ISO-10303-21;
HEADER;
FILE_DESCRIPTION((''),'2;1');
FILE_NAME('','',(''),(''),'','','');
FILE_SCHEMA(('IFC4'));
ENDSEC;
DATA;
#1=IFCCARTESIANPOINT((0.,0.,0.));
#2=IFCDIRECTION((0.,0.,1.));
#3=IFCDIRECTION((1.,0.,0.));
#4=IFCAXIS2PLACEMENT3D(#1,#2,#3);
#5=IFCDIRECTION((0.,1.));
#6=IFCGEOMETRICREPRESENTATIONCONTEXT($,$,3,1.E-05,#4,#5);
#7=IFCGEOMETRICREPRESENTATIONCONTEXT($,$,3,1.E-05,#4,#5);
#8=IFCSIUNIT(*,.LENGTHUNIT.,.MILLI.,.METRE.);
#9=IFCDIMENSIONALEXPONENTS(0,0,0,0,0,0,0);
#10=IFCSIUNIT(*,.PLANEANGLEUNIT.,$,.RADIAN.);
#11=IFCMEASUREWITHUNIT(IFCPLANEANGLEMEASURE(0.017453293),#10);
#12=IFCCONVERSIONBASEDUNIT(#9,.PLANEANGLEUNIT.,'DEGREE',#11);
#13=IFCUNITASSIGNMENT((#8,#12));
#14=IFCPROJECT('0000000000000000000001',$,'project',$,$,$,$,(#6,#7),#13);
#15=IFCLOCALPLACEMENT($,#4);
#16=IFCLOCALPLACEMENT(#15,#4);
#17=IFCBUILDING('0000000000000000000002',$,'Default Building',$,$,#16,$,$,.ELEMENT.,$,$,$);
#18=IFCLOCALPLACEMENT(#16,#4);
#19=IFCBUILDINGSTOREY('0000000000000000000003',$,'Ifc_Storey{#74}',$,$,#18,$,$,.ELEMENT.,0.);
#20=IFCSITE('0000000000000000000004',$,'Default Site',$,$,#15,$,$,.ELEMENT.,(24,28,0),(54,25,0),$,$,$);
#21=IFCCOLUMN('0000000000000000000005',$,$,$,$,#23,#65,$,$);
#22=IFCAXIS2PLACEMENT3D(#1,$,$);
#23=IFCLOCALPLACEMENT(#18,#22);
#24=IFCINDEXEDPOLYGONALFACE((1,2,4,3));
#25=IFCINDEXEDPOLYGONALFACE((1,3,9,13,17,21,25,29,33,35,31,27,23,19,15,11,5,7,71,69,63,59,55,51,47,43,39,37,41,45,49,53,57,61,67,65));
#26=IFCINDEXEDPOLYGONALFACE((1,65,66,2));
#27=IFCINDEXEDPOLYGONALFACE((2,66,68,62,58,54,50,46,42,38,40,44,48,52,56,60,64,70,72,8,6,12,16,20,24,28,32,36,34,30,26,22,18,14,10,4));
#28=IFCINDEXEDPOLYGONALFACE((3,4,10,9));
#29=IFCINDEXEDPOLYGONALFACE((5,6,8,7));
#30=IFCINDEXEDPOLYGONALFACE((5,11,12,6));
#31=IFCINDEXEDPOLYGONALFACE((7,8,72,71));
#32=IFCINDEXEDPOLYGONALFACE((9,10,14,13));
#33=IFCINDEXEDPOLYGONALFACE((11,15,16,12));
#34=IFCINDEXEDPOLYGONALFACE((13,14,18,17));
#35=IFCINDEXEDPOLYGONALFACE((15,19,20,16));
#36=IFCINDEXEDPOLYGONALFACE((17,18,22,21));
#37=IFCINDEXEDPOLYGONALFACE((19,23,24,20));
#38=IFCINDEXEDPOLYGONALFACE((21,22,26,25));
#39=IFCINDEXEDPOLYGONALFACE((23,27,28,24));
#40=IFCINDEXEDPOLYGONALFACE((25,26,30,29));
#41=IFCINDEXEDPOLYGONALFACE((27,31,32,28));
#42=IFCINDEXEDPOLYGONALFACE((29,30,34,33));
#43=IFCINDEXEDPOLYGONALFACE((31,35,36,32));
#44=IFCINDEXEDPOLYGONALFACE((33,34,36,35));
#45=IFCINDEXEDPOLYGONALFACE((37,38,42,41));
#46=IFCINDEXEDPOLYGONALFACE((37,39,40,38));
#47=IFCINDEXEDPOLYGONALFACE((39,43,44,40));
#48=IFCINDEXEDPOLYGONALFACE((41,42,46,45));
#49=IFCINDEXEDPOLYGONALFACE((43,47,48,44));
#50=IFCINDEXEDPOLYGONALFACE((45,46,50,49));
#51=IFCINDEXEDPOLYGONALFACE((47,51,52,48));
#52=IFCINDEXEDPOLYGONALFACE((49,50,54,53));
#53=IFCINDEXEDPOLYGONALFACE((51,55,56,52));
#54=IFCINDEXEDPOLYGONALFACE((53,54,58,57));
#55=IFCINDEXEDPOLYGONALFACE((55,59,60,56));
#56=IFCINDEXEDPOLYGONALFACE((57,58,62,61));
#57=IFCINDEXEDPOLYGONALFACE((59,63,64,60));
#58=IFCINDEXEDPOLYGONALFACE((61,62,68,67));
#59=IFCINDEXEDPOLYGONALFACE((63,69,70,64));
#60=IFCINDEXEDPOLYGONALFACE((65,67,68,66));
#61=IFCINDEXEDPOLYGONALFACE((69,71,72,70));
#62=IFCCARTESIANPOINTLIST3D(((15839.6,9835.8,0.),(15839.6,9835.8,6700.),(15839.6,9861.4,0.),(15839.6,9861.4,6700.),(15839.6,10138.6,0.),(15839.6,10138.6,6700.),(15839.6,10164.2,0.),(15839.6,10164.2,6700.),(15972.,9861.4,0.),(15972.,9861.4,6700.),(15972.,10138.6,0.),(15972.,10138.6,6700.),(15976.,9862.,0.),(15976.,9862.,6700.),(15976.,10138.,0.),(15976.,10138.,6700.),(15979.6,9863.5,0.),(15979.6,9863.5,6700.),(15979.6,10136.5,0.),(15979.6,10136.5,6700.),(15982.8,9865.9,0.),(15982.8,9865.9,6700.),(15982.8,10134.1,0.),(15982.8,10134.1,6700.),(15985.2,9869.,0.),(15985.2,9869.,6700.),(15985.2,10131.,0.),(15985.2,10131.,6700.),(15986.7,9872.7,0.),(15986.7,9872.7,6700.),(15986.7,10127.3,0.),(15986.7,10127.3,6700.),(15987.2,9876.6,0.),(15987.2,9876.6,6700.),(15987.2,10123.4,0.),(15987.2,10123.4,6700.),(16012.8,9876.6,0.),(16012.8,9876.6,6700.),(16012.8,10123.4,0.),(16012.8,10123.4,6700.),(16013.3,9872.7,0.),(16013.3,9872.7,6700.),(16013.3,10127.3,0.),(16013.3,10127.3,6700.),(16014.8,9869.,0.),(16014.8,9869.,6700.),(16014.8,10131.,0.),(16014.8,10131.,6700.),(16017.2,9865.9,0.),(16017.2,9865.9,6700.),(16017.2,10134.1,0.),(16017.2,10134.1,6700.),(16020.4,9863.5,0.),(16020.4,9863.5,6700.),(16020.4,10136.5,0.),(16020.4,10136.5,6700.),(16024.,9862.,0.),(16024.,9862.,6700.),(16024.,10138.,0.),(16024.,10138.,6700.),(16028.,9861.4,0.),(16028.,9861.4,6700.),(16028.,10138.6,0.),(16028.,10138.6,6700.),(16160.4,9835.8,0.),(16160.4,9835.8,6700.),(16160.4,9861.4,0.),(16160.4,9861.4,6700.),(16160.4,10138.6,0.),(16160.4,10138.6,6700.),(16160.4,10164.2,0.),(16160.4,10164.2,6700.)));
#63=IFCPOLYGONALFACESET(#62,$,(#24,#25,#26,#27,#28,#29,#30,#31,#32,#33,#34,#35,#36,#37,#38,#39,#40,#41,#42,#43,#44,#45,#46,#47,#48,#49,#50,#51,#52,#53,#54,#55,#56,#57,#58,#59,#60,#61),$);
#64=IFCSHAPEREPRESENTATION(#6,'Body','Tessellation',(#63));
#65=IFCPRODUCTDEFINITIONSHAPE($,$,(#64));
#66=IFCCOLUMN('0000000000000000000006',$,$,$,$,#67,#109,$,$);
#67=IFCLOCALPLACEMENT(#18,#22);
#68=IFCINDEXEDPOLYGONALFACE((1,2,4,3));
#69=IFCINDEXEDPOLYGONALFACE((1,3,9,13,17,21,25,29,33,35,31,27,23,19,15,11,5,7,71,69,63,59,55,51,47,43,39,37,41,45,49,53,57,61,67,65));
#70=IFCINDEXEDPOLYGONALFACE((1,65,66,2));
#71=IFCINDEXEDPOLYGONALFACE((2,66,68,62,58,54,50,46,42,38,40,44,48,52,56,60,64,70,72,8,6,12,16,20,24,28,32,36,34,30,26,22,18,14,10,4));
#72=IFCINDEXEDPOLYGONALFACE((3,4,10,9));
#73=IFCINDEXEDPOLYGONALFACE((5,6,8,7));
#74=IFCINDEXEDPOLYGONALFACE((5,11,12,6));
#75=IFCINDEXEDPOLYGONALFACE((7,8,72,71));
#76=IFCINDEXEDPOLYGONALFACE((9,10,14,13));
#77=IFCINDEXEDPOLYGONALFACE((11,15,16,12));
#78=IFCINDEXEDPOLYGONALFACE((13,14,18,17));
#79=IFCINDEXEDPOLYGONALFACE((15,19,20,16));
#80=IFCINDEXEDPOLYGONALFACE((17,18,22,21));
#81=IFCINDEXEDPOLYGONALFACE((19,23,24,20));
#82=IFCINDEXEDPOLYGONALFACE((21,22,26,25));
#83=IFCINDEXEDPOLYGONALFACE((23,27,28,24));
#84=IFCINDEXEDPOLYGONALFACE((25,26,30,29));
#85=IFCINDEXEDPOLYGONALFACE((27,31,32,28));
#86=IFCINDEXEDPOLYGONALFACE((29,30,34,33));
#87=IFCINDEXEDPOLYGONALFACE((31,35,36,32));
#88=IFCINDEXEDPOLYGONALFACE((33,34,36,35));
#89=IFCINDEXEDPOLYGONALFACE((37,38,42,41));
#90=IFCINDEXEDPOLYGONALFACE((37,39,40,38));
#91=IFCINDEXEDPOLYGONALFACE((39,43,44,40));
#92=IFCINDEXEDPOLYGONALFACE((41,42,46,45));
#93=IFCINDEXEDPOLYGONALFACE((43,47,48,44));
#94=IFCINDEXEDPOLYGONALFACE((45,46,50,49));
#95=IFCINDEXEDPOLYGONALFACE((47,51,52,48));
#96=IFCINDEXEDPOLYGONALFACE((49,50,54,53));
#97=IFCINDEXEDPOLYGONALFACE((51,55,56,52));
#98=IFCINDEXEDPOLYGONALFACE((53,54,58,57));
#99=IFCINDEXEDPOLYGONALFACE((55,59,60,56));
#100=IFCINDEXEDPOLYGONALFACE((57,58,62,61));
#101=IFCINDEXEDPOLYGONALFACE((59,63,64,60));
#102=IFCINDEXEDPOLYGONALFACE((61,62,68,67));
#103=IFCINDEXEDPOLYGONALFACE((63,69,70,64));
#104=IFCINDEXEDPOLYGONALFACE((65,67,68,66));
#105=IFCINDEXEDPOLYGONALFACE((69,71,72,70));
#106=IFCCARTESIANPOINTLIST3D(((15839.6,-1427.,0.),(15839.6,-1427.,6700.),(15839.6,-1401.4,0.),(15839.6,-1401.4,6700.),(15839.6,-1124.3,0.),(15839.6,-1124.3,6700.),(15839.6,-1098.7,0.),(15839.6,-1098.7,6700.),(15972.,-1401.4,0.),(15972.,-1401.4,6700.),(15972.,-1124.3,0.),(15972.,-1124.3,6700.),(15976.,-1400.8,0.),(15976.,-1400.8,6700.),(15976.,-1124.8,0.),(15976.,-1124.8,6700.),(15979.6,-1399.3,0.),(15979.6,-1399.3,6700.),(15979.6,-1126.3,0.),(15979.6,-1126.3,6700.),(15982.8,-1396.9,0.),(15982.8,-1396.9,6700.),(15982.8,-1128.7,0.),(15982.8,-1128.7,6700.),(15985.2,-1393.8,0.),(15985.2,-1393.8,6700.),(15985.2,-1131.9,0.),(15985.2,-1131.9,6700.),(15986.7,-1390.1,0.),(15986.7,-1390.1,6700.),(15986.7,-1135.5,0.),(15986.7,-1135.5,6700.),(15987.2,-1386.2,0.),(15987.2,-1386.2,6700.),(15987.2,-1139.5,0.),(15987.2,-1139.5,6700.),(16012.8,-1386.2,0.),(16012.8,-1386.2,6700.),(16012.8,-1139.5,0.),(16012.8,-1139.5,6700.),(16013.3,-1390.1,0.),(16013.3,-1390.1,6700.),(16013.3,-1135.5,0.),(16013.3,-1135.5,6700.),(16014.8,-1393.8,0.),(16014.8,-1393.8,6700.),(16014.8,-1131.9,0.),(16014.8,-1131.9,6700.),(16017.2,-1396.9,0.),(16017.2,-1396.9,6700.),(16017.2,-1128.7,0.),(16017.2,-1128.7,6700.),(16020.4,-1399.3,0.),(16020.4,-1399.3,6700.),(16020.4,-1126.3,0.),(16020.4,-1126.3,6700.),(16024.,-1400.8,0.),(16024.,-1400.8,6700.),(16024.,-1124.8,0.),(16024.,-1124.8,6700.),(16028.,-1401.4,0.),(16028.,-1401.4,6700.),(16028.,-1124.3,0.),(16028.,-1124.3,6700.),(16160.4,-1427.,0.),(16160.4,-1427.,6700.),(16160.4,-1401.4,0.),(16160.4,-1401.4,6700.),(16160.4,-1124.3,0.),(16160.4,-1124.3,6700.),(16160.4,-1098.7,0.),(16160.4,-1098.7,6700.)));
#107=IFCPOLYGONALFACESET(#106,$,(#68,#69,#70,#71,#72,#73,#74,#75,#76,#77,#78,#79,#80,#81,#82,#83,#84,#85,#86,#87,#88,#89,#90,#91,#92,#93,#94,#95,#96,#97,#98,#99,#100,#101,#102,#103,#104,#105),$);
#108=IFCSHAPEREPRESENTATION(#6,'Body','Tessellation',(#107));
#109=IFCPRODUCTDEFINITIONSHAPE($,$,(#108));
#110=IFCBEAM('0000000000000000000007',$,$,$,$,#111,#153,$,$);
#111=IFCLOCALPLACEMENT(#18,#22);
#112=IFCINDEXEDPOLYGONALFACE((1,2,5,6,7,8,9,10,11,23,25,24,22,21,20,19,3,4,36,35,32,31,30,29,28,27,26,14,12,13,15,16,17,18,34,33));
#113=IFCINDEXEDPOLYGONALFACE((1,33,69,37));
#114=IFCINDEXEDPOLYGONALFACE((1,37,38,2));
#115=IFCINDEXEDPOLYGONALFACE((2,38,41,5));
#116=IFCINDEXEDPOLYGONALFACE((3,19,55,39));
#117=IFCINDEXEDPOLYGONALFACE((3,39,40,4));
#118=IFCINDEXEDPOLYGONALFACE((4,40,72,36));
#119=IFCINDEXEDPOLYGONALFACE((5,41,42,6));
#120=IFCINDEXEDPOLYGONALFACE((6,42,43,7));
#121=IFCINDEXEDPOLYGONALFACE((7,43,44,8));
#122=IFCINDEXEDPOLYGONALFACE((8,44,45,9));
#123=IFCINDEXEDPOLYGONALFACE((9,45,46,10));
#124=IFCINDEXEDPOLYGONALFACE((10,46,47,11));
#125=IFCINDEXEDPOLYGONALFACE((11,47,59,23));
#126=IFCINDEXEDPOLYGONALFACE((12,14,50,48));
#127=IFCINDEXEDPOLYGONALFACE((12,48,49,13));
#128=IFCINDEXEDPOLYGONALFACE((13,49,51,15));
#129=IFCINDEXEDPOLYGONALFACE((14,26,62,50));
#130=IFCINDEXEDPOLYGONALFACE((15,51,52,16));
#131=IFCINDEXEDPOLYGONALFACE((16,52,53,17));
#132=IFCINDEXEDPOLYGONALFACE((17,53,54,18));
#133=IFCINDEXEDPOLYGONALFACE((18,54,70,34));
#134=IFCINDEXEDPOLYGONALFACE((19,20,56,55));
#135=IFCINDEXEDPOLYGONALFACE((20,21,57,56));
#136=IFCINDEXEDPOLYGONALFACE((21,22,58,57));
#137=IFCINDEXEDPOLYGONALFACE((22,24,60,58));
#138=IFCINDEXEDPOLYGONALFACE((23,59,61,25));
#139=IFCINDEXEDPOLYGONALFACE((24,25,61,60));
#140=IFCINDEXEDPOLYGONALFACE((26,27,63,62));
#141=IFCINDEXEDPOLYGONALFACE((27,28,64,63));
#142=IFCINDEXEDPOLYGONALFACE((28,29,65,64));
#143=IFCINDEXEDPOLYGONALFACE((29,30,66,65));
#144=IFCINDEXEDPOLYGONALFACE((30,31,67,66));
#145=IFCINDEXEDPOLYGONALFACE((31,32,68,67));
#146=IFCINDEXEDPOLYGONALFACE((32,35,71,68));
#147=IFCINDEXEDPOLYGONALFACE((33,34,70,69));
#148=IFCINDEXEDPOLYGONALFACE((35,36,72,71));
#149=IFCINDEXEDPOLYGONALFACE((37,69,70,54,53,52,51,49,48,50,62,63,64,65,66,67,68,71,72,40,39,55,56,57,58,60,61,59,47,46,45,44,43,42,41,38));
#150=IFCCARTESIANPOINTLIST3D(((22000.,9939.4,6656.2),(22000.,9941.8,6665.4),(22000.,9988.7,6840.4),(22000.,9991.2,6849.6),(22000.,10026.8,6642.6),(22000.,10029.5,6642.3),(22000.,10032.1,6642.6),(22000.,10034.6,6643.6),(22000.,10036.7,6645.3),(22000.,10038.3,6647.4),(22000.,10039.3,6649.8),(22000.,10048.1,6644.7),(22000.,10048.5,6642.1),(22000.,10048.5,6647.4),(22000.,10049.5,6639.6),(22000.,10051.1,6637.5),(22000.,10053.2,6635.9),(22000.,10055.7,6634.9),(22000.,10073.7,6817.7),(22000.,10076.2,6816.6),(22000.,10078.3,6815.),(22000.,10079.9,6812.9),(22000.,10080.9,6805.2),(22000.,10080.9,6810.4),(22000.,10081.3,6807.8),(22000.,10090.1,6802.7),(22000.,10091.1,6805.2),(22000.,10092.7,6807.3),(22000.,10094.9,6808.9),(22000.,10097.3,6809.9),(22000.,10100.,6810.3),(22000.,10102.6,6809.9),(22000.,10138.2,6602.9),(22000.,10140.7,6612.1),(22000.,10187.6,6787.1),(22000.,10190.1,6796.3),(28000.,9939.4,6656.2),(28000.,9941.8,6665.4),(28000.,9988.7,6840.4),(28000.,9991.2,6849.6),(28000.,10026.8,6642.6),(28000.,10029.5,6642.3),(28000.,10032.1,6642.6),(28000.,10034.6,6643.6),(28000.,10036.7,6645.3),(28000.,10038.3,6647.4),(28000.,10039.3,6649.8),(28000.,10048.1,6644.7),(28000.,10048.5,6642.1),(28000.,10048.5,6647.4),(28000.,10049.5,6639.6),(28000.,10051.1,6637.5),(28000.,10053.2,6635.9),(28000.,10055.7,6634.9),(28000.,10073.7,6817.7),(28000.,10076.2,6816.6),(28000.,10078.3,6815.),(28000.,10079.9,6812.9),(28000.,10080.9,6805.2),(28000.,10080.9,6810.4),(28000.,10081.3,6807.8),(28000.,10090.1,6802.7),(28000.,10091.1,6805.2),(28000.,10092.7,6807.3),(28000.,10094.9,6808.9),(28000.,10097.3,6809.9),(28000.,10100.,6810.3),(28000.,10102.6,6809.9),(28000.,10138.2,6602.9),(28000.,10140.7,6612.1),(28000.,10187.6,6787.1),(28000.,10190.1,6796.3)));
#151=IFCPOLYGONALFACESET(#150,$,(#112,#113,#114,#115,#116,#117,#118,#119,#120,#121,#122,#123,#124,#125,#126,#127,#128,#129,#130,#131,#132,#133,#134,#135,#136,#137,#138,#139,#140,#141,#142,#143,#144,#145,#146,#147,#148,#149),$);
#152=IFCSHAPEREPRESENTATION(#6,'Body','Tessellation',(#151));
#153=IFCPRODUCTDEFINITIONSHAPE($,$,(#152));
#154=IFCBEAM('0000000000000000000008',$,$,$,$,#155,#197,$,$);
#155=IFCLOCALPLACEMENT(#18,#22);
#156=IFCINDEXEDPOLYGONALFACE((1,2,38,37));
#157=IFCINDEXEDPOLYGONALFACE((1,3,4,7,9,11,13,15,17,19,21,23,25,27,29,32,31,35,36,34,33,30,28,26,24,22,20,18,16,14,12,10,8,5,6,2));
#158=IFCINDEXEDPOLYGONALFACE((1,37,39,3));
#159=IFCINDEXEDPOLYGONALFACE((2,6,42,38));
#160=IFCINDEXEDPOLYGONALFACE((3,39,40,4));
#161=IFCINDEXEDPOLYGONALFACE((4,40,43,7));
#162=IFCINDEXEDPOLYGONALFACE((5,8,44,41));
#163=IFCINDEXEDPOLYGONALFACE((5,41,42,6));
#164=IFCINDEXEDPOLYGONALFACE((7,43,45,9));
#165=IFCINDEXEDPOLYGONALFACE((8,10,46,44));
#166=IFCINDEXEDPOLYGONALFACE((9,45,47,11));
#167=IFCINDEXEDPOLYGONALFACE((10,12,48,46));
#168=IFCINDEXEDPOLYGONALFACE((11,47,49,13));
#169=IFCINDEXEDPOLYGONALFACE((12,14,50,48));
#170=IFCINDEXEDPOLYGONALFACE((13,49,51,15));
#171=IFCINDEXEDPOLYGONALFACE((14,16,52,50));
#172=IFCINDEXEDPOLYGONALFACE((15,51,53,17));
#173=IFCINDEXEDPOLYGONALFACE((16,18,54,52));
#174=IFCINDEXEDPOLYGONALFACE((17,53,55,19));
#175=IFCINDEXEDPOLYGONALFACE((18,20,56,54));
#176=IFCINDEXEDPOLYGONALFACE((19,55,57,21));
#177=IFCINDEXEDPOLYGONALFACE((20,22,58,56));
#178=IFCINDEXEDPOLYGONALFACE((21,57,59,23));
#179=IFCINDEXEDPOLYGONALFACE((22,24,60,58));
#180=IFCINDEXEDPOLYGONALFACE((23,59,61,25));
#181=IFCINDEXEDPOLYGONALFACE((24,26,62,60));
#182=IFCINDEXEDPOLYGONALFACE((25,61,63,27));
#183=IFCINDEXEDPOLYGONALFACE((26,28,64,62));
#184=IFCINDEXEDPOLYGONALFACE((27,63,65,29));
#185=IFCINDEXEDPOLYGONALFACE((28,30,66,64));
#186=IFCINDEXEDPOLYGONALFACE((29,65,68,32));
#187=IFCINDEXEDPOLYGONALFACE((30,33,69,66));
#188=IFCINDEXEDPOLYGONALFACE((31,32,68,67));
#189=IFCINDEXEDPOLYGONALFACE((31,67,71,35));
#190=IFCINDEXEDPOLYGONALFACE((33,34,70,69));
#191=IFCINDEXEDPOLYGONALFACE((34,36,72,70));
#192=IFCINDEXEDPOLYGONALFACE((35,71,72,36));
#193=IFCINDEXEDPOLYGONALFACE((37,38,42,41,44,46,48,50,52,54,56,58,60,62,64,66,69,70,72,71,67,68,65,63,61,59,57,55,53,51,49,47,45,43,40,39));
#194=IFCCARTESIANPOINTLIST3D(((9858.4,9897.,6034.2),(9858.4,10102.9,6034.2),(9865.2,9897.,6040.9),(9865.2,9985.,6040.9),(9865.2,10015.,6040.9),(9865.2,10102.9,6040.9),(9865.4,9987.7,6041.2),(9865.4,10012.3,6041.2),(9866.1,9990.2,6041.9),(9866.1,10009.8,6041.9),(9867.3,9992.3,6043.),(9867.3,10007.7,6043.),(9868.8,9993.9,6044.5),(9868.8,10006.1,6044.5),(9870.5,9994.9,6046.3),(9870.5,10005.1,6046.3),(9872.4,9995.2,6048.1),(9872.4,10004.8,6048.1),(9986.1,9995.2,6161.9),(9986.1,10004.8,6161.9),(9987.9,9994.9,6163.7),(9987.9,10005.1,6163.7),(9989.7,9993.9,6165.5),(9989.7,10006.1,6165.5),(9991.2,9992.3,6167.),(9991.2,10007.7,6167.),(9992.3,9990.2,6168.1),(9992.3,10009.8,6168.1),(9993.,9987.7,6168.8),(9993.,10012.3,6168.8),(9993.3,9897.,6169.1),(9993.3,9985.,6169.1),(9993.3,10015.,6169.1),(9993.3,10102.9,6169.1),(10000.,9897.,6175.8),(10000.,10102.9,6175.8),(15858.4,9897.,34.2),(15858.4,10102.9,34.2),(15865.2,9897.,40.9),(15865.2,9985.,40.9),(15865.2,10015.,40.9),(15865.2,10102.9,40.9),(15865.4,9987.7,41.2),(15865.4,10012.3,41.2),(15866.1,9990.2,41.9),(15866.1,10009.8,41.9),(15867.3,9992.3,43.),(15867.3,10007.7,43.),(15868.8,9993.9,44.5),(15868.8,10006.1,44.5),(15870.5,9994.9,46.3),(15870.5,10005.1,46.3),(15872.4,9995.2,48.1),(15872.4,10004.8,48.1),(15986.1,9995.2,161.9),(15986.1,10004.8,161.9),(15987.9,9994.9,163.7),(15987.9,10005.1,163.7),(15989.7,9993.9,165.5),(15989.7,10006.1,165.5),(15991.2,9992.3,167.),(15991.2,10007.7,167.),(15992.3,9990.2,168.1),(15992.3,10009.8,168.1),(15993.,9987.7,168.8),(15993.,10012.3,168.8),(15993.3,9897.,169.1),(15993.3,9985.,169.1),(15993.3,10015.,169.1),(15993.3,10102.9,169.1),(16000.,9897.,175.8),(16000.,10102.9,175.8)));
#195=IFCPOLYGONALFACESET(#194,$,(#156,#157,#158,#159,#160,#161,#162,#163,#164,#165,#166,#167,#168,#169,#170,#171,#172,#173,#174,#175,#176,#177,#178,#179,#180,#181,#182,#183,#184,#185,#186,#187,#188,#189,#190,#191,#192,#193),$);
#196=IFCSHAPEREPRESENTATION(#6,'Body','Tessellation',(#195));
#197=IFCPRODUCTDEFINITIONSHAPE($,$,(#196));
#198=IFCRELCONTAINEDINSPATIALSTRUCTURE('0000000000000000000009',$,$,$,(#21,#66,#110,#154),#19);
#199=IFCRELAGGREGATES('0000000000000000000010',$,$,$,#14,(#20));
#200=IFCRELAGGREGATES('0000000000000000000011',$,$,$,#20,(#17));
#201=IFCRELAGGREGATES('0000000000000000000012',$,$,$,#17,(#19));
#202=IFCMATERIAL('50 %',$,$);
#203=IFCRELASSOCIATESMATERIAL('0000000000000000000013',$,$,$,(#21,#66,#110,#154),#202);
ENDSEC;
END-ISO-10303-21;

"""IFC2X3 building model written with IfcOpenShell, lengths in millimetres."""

from ifc_helpers import new_model, entity, si_unit, converted_unit, direction, frame, origin_with_axes, origin_2d_with_axis, place, context, project, spatial, i_section, extrude, material, element, save


model = new_model("IFC2X3")

# Units and contexts
context_of_model_1 = context(None, 3, precision=1e-05, world=origin_with_axes(), true_north=direction((0.0, 1.0)))
context_of_model_2 = context(None, 3, precision=1e-05, world=origin_with_axes(), true_north=direction((0.0, 1.0)))
ifc_project = project(units=[si_unit("LENGTHUNIT", "METRE", prefix="MILLI"), converted_unit("PLANEANGLEUNIT", "DEGREE", entity("IfcPlaneAngleMeasure", 0.017453293), si_unit("PLANEANGLEUNIT", "RADIAN"), dimensions=[0, 0, 0, 0, 0, 0, 0])], contexts=[context_of_model_1, context_of_model_2])

# Site, building, storey
site_placement = place(None, origin_with_axes())
site = spatial("IfcSite", under=ifc_project, at=site_placement, Name="Default Site", CompositionType="ELEMENT", RefLatitude=(24, 28, 0), RefLongitude=(54, 25, 0))
building_placement = place(site_placement, origin_with_axes())
building = spatial("IfcBuilding", under=site, at=building_placement, Name="Default Building", CompositionType="ELEMENT")
storey_placement = place(building_placement, origin_with_axes())
storey = spatial("IfcBuildingStorey", under=building, at=storey_placement, Name="Ifc_Storey{#74}", CompositionType="ELEMENT", Elevation=0.0)

# Columns
ifc_material_1 = material(Name="50 %")
column_1_placement = place(storey_placement, frame((16000.0, 10000.0, 0.0), z_axis=(0.0, 0.0, 1.0), x_axis=(1.0, 0.0, 0.0)))
element("IfcColumn", 1, at=column_1_placement, inside=storey, material=ifc_material_1, context=context_of_model_1, shape_type="SweptSolid", body=[
    extrude(i_section(OverallWidth=320.9, OverallDepth=328.3, WebThickness=25.5, FlangeThickness=25.6, FilletRadius=15.2, at=origin_2d_with_axis()), origin_with_axes(), (0.0, 0.0, 1.0), 6700.0),
])
column_2_placement = place(storey_placement, frame((16000.0, -1262.8, 0.0), z_axis=(0.0, 0.0, 1.0), x_axis=(-1.0, 0.0, 0.0)))
element("IfcColumn", 2, at=column_2_placement, inside=storey, material=ifc_material_1, context=context_of_model_1, shape_type="SweptSolid", body=[
    extrude(i_section(OverallWidth=320.9, OverallDepth=328.3, WebThickness=25.5, FlangeThickness=25.6, FilletRadius=15.2, at=origin_2d_with_axis()), frame((0.0, 0.0, 0.0), z_axis=(0.0, 0.0, 1.0), x_axis=(-1.0, 0.0, 0.0)), (0.0, 0.0, 1.0), 6700.0),
])

# Beams
beam_1_placement = place(storey_placement, frame((22000.0, 10064.7, 6726.3), z_axis=(0.0, 0.258819, 0.965926), x_axis=(1.0, 0.0, 0.0)))
element("IfcBeam", 3, at=beam_1_placement, inside=storey, material=ifc_material_1, context=context_of_model_1, shape_type="SweptSolid", body=[
    extrude(i_section(OverallWidth=205.9, OverallDepth=200.2, WebThickness=9.5, FlangeThickness=9.5, FilletRadius=10.2, at=origin_2d_with_axis()), frame((0.0, 0.0, 0.0), z_axis=(1.0, 0.0, 0.0), x_axis=(0.0, 1.0, 0.0)), (0.0, 0.0, 1.0), 6000.0),
])
beam_2_placement = place(storey_placement, frame((15929.2, 10000.0, 105.0), z_axis=(0.0, 0.0, 1.0), x_axis=(1.0, 0.0, 0.0)))
element("IfcBeam", 4, at=beam_2_placement, inside=storey, material=ifc_material_1, context=context_of_model_1, shape_type="SweptSolid", body=[
    extrude(i_section(OverallWidth=205.9, OverallDepth=200.2, WebThickness=9.5, FlangeThickness=9.5, FilletRadius=10.2, at=origin_2d_with_axis()), frame((0.0, 0.0, 0.0), z_axis=(-0.707107, 0.0, 0.707107), x_axis=(0.0, 1.0, 0.0)), (0.0, 0.0, 1.0), 8485.3),
])

save(model, "model.ifc")
